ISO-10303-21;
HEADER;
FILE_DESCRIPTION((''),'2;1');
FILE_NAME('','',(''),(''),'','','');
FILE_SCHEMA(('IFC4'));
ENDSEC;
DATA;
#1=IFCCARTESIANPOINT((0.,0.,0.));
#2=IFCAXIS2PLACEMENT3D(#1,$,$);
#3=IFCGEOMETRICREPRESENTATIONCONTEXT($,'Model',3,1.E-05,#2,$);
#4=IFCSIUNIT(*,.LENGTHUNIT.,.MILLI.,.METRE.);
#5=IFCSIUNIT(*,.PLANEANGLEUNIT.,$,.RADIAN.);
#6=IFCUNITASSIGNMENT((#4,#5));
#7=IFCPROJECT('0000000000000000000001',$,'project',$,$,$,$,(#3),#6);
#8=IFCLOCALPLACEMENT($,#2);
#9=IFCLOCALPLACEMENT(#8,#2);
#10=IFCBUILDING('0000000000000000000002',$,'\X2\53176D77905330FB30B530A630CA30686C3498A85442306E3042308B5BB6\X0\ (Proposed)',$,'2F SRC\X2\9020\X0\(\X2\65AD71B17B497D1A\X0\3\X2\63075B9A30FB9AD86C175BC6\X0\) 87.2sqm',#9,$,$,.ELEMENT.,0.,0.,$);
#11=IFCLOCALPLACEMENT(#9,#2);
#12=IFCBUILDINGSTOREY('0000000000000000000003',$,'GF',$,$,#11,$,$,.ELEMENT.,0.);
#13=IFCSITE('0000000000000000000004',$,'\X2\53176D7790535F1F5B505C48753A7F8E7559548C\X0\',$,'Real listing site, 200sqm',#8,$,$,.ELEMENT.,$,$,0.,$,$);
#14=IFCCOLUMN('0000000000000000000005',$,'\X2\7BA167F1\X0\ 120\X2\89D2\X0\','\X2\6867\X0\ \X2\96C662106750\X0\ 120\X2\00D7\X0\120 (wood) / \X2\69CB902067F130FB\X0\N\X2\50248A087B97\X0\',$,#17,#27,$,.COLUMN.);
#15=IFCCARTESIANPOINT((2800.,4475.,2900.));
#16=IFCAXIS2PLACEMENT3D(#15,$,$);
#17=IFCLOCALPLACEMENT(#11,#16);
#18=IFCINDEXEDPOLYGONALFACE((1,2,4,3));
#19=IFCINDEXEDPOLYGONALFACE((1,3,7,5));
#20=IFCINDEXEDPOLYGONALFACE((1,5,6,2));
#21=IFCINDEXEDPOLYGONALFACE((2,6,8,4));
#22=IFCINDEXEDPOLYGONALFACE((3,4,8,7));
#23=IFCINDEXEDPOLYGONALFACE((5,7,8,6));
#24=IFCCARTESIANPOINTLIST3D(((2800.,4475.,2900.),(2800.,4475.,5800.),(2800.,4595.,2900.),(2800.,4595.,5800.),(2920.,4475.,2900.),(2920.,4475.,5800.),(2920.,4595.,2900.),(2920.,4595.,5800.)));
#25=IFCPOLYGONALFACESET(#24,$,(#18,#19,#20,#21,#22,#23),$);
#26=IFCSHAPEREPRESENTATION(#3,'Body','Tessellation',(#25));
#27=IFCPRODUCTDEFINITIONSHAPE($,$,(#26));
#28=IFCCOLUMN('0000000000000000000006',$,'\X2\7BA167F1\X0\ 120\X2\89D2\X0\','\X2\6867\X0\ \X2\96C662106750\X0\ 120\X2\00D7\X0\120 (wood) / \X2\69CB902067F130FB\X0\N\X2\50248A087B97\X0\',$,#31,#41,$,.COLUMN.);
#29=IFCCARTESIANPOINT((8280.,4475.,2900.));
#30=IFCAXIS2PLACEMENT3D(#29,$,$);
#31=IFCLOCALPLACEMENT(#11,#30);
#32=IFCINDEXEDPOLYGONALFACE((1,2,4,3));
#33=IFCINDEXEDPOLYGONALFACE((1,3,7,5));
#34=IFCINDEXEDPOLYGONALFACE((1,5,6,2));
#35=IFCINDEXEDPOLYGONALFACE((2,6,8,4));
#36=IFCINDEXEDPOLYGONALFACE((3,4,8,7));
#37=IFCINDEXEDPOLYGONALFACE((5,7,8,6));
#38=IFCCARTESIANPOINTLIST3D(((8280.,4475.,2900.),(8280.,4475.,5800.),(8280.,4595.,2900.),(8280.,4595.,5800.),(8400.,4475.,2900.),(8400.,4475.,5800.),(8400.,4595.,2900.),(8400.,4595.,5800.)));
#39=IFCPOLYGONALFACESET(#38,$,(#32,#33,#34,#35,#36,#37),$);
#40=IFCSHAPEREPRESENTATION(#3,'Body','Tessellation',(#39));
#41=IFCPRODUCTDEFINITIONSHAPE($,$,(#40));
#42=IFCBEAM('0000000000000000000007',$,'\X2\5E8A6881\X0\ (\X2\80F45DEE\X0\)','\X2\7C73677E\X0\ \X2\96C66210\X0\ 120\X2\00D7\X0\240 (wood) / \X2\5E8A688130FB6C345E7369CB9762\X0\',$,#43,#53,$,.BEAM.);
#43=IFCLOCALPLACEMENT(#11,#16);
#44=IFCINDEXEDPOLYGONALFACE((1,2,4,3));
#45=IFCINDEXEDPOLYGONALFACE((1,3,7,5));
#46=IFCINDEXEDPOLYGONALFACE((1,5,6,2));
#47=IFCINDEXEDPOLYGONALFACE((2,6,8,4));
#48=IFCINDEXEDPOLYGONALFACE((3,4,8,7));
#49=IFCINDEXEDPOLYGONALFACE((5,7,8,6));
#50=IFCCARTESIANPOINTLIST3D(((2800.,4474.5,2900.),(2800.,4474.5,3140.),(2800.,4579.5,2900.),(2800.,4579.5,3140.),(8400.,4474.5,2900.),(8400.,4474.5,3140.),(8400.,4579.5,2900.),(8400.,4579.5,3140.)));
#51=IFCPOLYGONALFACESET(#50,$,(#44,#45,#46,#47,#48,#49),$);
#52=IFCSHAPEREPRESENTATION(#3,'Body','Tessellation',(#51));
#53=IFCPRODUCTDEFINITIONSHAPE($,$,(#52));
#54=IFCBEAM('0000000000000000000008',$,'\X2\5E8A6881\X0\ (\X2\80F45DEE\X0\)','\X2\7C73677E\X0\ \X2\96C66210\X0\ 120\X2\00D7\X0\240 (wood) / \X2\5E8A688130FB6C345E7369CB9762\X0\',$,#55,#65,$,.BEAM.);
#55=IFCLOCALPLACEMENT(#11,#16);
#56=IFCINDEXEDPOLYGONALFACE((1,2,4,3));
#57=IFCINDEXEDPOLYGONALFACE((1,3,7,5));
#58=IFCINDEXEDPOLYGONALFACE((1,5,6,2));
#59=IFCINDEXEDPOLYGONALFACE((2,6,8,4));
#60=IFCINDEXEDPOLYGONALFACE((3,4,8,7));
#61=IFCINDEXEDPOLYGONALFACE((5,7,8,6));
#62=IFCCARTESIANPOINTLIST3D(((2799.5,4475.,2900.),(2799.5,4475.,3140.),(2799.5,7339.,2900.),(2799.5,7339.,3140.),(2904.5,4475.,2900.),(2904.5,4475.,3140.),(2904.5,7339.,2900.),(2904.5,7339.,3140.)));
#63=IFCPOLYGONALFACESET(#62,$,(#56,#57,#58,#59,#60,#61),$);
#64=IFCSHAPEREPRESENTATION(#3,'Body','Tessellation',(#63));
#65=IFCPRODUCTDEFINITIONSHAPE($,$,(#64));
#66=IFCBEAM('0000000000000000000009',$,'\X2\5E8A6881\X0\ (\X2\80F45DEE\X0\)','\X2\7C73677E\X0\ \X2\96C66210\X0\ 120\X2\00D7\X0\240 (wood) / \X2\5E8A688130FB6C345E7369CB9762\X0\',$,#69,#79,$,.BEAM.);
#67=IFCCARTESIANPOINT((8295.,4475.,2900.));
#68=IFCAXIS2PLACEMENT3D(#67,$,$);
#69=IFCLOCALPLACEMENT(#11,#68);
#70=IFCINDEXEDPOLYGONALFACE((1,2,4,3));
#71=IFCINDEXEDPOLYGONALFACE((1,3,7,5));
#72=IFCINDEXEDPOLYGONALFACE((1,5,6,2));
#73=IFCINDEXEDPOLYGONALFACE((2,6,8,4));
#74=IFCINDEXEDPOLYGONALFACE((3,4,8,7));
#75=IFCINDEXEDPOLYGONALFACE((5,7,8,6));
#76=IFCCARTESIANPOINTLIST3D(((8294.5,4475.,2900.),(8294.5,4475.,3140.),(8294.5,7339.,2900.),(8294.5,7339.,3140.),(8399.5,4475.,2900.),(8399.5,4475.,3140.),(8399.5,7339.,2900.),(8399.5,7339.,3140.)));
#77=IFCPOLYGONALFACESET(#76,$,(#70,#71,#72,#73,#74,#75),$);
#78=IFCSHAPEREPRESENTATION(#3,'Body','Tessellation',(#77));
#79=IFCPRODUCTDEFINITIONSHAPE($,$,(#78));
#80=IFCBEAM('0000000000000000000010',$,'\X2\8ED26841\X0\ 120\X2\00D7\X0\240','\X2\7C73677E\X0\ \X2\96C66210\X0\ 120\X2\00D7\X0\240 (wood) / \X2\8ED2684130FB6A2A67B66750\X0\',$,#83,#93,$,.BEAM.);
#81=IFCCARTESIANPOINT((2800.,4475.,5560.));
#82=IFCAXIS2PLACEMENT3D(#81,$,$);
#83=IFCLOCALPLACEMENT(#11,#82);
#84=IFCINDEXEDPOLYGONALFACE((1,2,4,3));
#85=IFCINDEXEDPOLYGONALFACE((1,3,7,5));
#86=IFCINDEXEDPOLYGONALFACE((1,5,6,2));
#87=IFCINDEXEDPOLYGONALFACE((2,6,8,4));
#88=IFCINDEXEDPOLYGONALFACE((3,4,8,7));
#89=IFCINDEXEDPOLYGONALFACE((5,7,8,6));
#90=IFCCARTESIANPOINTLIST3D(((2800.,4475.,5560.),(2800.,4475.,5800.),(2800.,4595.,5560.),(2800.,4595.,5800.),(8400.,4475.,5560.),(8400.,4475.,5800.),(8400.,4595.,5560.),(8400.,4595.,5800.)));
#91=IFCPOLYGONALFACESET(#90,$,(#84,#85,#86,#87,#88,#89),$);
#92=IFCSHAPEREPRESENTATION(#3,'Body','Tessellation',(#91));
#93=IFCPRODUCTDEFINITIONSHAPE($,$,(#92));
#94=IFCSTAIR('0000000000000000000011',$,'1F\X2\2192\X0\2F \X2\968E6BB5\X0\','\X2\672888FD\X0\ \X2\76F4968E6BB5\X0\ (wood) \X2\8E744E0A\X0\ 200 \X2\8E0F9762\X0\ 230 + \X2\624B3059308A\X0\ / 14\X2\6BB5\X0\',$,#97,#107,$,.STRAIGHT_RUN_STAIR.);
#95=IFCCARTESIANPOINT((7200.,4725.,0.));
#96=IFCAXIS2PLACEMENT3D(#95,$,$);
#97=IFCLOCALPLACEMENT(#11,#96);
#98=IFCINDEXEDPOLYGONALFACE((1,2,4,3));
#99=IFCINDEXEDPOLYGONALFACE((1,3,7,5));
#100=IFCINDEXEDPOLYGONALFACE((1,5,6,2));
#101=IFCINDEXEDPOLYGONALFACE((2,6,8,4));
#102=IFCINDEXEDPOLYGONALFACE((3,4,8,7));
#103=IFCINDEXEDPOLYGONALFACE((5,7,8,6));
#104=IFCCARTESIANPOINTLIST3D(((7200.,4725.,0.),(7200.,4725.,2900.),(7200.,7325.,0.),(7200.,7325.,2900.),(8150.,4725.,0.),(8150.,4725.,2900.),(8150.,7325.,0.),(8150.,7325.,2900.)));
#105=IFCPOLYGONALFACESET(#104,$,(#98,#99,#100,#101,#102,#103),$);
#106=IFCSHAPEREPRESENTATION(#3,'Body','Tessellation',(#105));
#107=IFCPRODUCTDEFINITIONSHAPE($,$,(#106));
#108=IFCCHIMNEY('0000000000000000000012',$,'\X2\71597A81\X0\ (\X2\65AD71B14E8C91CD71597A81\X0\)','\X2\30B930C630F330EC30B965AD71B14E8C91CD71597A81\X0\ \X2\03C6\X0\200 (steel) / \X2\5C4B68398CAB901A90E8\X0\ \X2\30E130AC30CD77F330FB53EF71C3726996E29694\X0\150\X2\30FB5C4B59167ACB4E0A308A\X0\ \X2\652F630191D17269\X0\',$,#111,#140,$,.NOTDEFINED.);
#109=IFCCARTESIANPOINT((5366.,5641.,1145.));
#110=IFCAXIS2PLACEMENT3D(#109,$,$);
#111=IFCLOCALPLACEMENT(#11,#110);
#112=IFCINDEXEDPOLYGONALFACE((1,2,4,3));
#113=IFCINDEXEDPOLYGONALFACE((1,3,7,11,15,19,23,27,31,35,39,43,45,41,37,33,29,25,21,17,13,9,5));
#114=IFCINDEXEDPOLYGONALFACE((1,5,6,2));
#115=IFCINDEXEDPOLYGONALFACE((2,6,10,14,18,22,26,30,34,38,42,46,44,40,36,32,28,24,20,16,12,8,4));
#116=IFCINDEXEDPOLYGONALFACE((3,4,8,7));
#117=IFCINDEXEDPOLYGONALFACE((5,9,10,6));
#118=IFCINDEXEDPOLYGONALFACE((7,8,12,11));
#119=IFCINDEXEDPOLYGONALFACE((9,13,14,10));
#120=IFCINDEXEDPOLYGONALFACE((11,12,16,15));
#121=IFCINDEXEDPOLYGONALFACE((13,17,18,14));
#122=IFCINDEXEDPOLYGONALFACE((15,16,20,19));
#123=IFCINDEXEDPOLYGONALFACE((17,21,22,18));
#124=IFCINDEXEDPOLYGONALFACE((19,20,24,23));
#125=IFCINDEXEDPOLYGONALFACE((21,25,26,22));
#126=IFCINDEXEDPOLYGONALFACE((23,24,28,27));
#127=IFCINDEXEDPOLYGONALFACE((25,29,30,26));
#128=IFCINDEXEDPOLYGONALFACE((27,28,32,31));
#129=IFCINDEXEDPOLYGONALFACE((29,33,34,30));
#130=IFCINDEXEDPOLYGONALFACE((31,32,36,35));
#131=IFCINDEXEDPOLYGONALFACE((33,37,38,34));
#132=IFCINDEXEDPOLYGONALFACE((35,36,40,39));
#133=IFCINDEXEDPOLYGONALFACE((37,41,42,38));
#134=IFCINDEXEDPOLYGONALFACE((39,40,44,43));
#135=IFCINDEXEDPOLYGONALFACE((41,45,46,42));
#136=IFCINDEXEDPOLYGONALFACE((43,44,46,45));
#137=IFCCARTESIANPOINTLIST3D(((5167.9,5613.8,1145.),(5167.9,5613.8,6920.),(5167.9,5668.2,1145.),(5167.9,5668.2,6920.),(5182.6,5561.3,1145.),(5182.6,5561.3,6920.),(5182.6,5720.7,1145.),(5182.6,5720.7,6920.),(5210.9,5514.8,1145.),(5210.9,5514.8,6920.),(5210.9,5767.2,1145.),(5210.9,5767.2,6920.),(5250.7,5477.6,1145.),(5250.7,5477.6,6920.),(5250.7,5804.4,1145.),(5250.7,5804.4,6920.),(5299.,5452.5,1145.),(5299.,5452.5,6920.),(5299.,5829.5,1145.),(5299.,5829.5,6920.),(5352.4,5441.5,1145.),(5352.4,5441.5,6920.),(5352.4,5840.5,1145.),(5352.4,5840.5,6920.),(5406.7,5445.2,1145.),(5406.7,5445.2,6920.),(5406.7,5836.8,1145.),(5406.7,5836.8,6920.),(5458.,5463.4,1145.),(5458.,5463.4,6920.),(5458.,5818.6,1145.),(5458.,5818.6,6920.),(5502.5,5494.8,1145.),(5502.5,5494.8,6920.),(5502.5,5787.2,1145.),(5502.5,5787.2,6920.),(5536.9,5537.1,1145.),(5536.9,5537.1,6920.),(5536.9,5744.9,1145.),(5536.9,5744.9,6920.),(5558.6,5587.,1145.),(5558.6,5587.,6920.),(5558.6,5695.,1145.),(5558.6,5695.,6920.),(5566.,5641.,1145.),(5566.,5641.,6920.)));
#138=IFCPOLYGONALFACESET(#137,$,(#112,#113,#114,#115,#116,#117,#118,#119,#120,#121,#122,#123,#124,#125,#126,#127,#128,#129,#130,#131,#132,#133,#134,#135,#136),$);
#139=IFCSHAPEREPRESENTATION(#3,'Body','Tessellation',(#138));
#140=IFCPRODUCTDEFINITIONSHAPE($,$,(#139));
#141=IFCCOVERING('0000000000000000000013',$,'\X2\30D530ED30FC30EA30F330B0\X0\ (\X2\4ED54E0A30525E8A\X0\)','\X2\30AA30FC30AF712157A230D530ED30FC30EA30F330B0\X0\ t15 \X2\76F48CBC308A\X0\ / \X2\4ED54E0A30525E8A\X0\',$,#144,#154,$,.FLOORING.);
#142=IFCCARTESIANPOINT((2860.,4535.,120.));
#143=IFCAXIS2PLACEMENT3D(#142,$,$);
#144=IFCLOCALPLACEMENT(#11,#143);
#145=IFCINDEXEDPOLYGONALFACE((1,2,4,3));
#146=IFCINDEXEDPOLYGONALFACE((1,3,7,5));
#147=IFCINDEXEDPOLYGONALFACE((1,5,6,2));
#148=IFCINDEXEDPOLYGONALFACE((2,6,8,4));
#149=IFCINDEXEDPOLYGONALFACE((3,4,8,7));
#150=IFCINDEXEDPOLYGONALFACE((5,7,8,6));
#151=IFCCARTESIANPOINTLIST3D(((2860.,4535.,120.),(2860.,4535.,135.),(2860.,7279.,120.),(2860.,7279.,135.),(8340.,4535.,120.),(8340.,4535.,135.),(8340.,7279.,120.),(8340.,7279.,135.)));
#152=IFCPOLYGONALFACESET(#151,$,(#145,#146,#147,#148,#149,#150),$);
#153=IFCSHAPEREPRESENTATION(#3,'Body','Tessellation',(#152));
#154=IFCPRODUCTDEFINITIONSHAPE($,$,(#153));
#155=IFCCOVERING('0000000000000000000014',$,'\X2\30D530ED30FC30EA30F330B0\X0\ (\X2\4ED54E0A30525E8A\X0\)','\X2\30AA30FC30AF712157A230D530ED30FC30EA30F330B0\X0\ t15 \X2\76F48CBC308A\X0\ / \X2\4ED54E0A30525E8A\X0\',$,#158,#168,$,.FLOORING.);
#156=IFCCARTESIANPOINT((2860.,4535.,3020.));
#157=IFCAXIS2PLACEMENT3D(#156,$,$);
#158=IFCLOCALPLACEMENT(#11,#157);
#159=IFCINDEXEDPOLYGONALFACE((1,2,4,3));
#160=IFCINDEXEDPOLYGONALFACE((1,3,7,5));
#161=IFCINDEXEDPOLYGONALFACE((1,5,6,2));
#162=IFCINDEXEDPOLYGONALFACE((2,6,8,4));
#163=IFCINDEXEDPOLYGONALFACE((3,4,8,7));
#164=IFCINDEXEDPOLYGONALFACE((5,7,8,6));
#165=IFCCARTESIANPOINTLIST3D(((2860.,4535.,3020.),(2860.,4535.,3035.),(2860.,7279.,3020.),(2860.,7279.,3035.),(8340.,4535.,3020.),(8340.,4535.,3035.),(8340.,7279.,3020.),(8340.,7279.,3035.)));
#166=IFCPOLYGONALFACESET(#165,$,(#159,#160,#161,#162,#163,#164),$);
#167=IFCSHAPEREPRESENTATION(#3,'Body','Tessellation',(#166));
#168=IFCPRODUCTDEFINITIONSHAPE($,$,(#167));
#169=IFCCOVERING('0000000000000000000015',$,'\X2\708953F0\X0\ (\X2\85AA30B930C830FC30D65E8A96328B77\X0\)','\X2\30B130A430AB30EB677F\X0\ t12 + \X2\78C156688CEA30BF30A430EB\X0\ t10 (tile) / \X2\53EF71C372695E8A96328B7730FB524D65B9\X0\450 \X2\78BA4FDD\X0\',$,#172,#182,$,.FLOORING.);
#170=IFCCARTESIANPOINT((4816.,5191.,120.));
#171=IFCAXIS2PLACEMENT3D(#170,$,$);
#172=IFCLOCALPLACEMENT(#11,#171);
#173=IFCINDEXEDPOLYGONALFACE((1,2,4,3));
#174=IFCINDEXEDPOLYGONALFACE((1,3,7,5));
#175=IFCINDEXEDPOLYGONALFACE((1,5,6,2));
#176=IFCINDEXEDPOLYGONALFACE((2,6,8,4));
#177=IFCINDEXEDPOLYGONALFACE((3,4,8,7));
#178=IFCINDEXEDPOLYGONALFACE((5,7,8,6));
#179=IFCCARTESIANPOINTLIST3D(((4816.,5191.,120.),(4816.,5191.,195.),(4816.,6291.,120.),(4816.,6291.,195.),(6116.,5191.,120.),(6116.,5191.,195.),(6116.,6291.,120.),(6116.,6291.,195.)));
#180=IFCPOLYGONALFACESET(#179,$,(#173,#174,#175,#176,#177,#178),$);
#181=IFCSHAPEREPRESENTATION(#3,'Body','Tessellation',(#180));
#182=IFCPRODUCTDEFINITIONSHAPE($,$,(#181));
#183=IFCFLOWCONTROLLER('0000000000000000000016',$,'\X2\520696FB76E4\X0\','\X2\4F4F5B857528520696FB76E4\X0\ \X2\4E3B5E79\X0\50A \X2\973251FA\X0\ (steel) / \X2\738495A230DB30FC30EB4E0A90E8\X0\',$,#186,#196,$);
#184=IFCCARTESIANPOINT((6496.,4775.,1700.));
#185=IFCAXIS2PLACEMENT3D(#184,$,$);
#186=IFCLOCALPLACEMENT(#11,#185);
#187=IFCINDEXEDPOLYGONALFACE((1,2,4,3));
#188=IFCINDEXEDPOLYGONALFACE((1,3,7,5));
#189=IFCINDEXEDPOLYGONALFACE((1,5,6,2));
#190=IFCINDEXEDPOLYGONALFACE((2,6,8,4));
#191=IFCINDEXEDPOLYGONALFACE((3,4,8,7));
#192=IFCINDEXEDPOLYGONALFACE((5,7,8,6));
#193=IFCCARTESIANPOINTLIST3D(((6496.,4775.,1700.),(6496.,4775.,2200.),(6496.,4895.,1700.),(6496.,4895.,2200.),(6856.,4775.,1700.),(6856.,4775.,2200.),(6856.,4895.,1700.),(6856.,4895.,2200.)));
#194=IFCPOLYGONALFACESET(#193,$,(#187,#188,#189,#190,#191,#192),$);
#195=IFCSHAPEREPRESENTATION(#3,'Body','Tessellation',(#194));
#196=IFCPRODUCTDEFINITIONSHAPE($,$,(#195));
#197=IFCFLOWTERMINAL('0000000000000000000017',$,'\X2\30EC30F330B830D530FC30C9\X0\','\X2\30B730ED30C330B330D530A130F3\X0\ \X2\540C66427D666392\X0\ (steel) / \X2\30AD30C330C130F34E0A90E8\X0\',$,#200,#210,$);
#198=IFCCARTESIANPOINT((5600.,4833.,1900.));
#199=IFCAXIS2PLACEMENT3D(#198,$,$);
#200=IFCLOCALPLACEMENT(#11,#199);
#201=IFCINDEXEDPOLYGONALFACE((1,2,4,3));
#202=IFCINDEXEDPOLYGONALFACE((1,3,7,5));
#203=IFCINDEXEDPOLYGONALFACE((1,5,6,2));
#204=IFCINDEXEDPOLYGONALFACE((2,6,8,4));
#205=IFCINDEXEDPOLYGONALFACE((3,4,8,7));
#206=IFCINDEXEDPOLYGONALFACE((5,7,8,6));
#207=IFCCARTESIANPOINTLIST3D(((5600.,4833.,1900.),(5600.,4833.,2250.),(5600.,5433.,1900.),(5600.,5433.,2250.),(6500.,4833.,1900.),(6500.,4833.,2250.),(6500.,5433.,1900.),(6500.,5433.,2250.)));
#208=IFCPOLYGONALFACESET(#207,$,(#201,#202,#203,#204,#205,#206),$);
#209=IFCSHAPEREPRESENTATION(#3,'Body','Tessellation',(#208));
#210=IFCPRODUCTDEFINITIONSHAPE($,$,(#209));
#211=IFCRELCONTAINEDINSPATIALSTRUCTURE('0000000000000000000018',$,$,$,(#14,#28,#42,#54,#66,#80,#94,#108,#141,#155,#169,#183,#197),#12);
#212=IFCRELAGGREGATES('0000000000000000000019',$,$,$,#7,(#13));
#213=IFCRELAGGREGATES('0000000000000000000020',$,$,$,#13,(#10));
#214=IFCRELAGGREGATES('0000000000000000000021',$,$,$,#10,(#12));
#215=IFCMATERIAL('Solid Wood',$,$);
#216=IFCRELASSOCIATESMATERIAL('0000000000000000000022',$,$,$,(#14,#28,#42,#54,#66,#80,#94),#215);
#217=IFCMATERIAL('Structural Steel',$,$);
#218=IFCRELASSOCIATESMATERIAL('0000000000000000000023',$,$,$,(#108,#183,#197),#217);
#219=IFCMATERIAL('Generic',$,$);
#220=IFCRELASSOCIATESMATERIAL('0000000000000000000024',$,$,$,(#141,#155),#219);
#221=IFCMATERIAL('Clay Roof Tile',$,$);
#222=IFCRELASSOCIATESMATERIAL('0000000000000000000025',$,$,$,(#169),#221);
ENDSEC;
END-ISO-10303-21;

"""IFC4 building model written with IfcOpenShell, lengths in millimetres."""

from ifc_helpers import new_model, si_unit, frame, frame_2d, origin, origin_2d, place, context, project, spatial, rectangle, circle, extrude, material, element, save


model = new_model("IFC4")

# Units and contexts
model_context = context("Model", 3, precision=1e-05, world=origin())
ifc_project = project(units=[si_unit("LENGTHUNIT", "METRE", prefix="MILLI"), si_unit("PLANEANGLEUNIT", "RADIAN")], contexts=[model_context])

# Site, building, storey
site_placement = place(None, origin())
site = spatial("IfcSite", under=ifc_project, at=site_placement, Name="北海道弟子屈町美留和", ObjectType="Real listing site, 200sqm", CompositionType="ELEMENT", RefElevation=0.0)
building_placement = place(site_placement, origin())
building = spatial("IfcBuilding", under=site, at=building_placement, Name="北海道・サウナと水風呂のある家 (Proposed)", ObjectType="2F SRC造(断熱等級3指定・高気密) 87.2sqm", CompositionType="ELEMENT", ElevationOfRefHeight=0.0, ElevationOfTerrain=0.0)
storey_placement = place(building_placement, origin())
storey = spatial("IfcBuildingStorey", under=building, at=storey_placement, Name="GF", CompositionType="ELEMENT", Elevation=0.0)

# Columns
ifc_material_1 = material(Name="Solid Wood")
column_1_placement = place(storey_placement, frame((2800.0, 4475.0, 2900.0)))
element("IfcColumn", 1, at=column_1_placement, inside=storey, material=ifc_material_1, Name="管柱 120角", Description="桧 集成材 120×120 (wood) / 構造柱・N値計算", PredefinedType="COLUMN", context=model_context, shape_type="SweptSolid", body=[
    extrude(rectangle(XDim=120.0, YDim=120.0, at=frame_2d((60.0, 60.0))), frame((2800.0, 4475.0, 2900.0)), (0.0, 0.0, 1.0), 2900.0),
])
column_2_placement = place(storey_placement, frame((8280.0, 4475.0, 2900.0)))
element("IfcColumn", 2, at=column_2_placement, inside=storey, material=ifc_material_1, Name="管柱 120角", Description="桧 集成材 120×120 (wood) / 構造柱・N値計算", PredefinedType="COLUMN", context=model_context, shape_type="SweptSolid", body=[
    extrude(rectangle(XDim=120.0, YDim=120.0, at=frame_2d((60.0, 60.0))), frame((8280.0, 4475.0, 2900.0)), (0.0, 0.0, 1.0), 2900.0),
])

# Beams
beam_1_placement = place(storey_placement, frame((2800.0, 4475.0, 2900.0)))
element("IfcBeam", 3, at=beam_1_placement, inside=storey, material=ifc_material_1, Name="床梁 (胴差)", Description="米松 集成 120×240 (wood) / 床梁・水平構面", PredefinedType="BEAM", context=model_context, shape_type="SweptSolid", body=[
    extrude(rectangle(XDim=5600.0, YDim=105.0, at=frame_2d((2800.0, 52.0))), frame((2800.0, 4475.0, 2900.0)), (0.0, 0.0, 1.0), 240.0),
])
beam_2_placement = place(storey_placement, frame((2800.0, 4475.0, 2900.0)))
element("IfcBeam", 4, at=beam_2_placement, inside=storey, material=ifc_material_1, Name="床梁 (胴差)", Description="米松 集成 120×240 (wood) / 床梁・水平構面", PredefinedType="BEAM", context=model_context, shape_type="SweptSolid", body=[
    extrude(rectangle(XDim=105.0, YDim=2864.0, at=frame_2d((52.0, 1432.0))), frame((2800.0, 4475.0, 2900.0)), (0.0, 0.0, 1.0), 240.0),
])
beam_3_placement = place(storey_placement, frame((8295.0, 4475.0, 2900.0)))
element("IfcBeam", 5, at=beam_3_placement, inside=storey, material=ifc_material_1, Name="床梁 (胴差)", Description="米松 集成 120×240 (wood) / 床梁・水平構面", PredefinedType="BEAM", context=model_context, shape_type="SweptSolid", body=[
    extrude(rectangle(XDim=105.0, YDim=2864.0, at=frame_2d((52.0, 1432.0))), frame((8295.0, 4475.0, 2900.0)), (0.0, 0.0, 1.0), 240.0),
])
beam_4_placement = place(storey_placement, frame((2800.0, 4475.0, 5560.0)))
element("IfcBeam", 6, at=beam_4_placement, inside=storey, material=ifc_material_1, Name="軒桁 120×240", Description="米松 集成 120×240 (wood) / 軒桁・横架材", PredefinedType="BEAM", context=model_context, shape_type="SweptSolid", body=[
    extrude(rectangle(XDim=5600.0, YDim=120.0, at=frame_2d((2800.0, 60.0))), frame((2800.0, 4475.0, 5560.0)), (0.0, 0.0, 1.0), 240.0),
])

# Stair
stair_placement = place(storey_placement, frame((7200.0, 4725.0, 0.0)))
element("IfcStair", 7, at=stair_placement, inside=storey, material=ifc_material_1, Name="1F→2F 階段", Description="木製 直階段 (wood) 蹴上 200 踏面 230 + 手すり / 14段", PredefinedType="STRAIGHT_RUN_STAIR", context=model_context, shape_type="SweptSolid", body=[
    extrude(rectangle(XDim=950.0, YDim=2600.0, at=frame_2d((475.0, 1300.0))), frame((7200.0, 4725.0, 0.0)), (0.0, 0.0, 1.0), 2900.0),
])

# Chimney
ifc_material_2 = material(Name="Structural Steel")
chimney_placement = place(storey_placement, frame((5366.0, 5641.0, 1145.0)))
element("IfcChimney", 8, at=chimney_placement, inside=storey, material=ifc_material_2, Name="煙突 (断熱二重煙突)", Description="ステンレス断熱二重煙突 φ200 (steel) / 屋根貫通部 メガネ石・可燃物離隔150・屋外立上り 支持金物", PredefinedType="NOTDEFINED", context=model_context, shape_type="SweptSolid", body=[
    extrude(circle(Radius=200.0, at=origin_2d()), frame((5366.0, 5641.0, 1145.0)), (0.0, 0.0, 1.0), 5775.0),
])

# Coverings
ifc_material_3 = material(Name="Generic")
covering_1_placement = place(storey_placement, frame((2860.0, 4535.0, 120.0)))
element("IfcCovering", 9, at=covering_1_placement, inside=storey, material=ifc_material_3, Name="フローリング (仕上げ床)", Description="オーク無垢フローリング t15 直貼り / 仕上げ床", PredefinedType="FLOORING", context=model_context, shape_type="SweptSolid", body=[
    extrude(rectangle(XDim=5480.0, YDim=2744.0, at=frame_2d((2740.0, 1372.0))), frame((2860.0, 4535.0, 120.0)), (0.0, 0.0, 1.0), 15.0),
])
covering_2_placement = place(storey_placement, frame((2860.0, 4535.0, 3020.0)))
element("IfcCovering", 10, at=covering_2_placement, inside=storey, material=ifc_material_3, Name="フローリング (仕上げ床)", Description="オーク無垢フローリング t15 直貼り / 仕上げ床", PredefinedType="FLOORING", context=model_context, shape_type="SweptSolid", body=[
    extrude(rectangle(XDim=5480.0, YDim=2744.0, at=frame_2d((2740.0, 1372.0))), frame((2860.0, 4535.0, 3020.0)), (0.0, 0.0, 1.0), 15.0),
])
ifc_material_4 = material(Name="Clay Roof Tile")
covering_3_placement = place(storey_placement, frame((4816.0, 5191.0, 120.0)))
element("IfcCovering", 11, at=covering_3_placement, inside=storey, material=ifc_material_4, Name="炉台 (薪ストーブ床防護)", Description="ケイカル板 t12 + 磁器質タイル t10 (tile) / 可燃物床防護・前方450 確保", PredefinedType="FLOORING", context=model_context, shape_type="SweptSolid", body=[
    extrude(rectangle(XDim=1300.0, YDim=1100.0, at=frame_2d((650.0, 550.0))), frame((4816.0, 5191.0, 120.0)), (0.0, 0.0, 1.0), 75.0),
])

# Flow controller
flow_controller_placement = place(storey_placement, frame((6496.0, 4775.0, 1700.0)))
element("IfcFlowController", 12, at=flow_controller_placement, inside=storey, material=ifc_material_2, Name="分電盤", Description="住宅用分電盤 主幹50A 露出 (steel) / 玄関ホール上部", context=model_context, shape_type="SweptSolid", body=[
    extrude(rectangle(XDim=360.0, YDim=120.0, at=frame_2d((180.0, 60.0))), frame((6496.0, 4775.0, 1700.0)), (0.0, 0.0, 1.0), 500.0),
])

# Flow terminal
flow_terminal_1_placement = place(storey_placement, frame((5600.0, 4833.0, 1900.0)))
element("IfcFlowTerminal", 13, at=flow_terminal_1_placement, inside=storey, material=ifc_material_2, Name="レンジフード", Description="シロッコファン 同時給排 (steel) / キッチン上部", context=model_context, shape_type="SweptSolid", body=[
    extrude(rectangle(XDim=900.0, YDim=600.0, at=frame_2d((450.0, 300.0))), frame((5600.0, 4833.0, 1900.0)), (0.0, 0.0, 1.0), 350.0),
])

save(model, "model.ifc")
